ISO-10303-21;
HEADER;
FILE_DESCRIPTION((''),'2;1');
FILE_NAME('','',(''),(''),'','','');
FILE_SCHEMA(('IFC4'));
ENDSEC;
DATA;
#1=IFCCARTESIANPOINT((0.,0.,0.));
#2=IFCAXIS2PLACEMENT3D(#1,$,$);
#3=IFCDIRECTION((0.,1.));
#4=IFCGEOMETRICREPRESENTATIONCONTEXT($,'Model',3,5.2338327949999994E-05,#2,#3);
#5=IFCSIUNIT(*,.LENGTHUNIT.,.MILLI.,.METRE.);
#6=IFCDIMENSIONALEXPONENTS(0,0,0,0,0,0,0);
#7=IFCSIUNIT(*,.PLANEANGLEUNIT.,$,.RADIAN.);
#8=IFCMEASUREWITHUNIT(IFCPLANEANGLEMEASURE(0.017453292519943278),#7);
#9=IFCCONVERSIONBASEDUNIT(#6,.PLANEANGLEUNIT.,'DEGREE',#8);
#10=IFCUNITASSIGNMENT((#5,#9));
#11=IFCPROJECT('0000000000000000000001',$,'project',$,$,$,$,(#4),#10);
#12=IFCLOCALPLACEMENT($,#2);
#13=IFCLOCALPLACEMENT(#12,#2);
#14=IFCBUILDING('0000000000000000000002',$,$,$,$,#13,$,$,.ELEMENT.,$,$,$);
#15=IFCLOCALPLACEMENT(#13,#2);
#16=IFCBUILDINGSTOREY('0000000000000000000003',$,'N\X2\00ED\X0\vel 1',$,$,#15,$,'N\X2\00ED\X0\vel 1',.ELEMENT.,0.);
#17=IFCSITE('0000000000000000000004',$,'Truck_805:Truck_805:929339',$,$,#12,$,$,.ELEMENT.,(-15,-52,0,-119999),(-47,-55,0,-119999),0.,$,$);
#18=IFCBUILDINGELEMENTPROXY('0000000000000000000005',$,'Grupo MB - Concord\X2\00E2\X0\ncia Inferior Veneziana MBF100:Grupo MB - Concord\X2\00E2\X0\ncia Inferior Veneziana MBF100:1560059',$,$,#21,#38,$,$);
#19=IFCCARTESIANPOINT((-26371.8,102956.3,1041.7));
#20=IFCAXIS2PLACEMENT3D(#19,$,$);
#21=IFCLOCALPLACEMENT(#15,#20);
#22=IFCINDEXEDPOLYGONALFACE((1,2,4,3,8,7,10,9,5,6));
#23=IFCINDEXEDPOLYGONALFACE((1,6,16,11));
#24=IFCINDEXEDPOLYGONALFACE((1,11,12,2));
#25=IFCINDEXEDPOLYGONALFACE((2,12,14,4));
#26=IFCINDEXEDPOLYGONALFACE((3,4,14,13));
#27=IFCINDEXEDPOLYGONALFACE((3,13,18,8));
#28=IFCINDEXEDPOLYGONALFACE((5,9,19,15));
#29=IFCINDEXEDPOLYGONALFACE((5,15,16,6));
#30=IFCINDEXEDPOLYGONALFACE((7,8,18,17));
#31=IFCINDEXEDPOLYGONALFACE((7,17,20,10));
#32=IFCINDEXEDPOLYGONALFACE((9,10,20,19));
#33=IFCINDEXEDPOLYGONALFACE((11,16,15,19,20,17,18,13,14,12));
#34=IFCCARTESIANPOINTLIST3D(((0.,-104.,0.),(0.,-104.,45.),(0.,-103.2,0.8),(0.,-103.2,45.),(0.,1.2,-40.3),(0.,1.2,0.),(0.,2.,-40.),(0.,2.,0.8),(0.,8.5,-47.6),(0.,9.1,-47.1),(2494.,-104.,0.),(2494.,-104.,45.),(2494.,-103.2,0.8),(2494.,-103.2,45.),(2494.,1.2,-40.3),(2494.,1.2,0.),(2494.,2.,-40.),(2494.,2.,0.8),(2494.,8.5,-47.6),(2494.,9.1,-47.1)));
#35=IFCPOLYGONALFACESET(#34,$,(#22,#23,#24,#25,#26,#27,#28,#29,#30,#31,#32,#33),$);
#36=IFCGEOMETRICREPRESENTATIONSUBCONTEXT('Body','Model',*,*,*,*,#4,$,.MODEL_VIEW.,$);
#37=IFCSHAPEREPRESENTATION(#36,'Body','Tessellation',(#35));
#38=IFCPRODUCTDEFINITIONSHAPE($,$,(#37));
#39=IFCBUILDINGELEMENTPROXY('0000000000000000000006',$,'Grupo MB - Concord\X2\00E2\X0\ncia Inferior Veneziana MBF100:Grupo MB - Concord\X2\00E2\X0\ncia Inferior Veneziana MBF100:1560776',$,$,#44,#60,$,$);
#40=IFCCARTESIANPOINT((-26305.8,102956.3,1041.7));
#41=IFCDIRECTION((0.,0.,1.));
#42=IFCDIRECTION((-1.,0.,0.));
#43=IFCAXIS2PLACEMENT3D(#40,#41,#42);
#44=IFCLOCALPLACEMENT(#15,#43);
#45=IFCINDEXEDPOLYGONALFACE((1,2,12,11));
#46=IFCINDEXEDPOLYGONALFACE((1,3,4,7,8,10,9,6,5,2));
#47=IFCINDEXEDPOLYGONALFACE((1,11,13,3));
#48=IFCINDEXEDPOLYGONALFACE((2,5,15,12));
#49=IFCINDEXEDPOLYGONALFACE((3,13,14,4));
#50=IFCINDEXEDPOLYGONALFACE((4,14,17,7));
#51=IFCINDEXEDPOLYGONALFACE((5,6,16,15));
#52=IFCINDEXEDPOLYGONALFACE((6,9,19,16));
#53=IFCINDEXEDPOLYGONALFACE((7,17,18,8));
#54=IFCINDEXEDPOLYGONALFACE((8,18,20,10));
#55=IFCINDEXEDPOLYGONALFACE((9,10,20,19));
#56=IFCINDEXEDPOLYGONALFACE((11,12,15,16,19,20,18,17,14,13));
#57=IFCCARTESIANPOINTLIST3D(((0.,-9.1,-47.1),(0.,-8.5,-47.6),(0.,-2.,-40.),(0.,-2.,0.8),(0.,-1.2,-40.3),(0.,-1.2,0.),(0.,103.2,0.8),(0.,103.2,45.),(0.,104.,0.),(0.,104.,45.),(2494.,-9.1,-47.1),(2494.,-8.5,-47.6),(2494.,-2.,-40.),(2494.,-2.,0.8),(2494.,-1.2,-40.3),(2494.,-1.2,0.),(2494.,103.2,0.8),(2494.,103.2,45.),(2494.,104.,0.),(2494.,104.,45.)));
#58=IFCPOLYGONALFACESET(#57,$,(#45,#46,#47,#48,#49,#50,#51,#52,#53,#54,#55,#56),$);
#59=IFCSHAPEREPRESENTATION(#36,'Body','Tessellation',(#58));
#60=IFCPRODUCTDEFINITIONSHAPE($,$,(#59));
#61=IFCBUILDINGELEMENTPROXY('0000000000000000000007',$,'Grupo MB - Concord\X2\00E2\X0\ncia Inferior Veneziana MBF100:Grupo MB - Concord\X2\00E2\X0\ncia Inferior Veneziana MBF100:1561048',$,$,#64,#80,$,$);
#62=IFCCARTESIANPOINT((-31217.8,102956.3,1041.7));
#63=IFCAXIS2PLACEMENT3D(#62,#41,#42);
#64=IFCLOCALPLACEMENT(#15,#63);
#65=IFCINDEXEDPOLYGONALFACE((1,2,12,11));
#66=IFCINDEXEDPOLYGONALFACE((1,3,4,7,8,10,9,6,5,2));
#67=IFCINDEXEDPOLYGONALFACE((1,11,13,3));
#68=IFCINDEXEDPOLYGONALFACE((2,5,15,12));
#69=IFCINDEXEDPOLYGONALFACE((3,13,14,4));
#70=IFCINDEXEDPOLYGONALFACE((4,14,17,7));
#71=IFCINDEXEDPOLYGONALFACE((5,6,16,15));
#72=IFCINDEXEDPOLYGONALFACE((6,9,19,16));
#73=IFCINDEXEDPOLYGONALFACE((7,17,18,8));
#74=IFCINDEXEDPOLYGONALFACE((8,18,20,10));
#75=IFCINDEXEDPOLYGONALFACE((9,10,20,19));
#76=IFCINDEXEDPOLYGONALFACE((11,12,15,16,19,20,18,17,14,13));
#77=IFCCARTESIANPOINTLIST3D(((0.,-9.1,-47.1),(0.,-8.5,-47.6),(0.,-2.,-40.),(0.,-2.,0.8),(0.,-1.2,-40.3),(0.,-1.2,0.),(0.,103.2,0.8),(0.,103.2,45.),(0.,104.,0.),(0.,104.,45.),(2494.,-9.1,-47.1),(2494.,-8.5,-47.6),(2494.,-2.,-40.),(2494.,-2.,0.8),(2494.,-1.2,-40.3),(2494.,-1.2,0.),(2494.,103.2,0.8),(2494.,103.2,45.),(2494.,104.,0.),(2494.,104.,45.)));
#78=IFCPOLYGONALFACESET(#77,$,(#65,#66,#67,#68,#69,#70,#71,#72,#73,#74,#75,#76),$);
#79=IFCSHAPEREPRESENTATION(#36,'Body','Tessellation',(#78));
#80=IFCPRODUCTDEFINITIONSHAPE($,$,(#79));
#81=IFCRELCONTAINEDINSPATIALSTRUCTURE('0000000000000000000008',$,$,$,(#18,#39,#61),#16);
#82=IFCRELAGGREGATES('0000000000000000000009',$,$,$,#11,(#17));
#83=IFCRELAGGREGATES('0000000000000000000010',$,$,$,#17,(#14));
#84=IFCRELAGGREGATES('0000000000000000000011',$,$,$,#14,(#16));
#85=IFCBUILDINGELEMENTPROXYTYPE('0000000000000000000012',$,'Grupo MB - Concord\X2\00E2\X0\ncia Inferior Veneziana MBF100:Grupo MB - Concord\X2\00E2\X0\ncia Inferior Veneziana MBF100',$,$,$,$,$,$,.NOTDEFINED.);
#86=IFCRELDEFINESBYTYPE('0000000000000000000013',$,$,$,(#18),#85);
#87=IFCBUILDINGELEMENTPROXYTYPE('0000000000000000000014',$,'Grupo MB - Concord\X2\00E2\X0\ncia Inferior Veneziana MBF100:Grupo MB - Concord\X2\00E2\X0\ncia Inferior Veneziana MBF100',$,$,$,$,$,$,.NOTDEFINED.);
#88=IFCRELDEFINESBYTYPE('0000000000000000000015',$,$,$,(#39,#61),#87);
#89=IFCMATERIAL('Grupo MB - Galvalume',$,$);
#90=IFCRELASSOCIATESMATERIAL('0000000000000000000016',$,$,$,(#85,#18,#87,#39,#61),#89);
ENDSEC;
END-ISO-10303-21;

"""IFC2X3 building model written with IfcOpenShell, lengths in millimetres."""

from ifc_helpers import new_model, entity, si_unit, converted_unit, direction, frame, origin, place, context, subcontext, project, spatial, polyline, outline, extrude, source, transform, mapped, material, type_object, type_shapes, element, save


model = new_model("IFC2X3")

# Units and contexts
model_context = context("Model", 3, precision=5.2338327949999994e-05, world=origin(), true_north=direction((0.0, 1.0)))
body_context = subcontext(model_context, "Body", "Model", "MODEL_VIEW")
ifc_project = project(units=[si_unit("LENGTHUNIT", "METRE", prefix="MILLI"), converted_unit("PLANEANGLEUNIT", "DEGREE", entity("IfcPlaneAngleMeasure", 0.017453292519943278), si_unit("PLANEANGLEUNIT", "RADIAN"), dimensions=[0, 0, 0, 0, 0, 0, 0])], contexts=[model_context])

# Site, building, storey
site_placement = place(None, origin())
site = spatial("IfcSite", under=ifc_project, at=site_placement, Name="Truck_805:Truck_805:929339", CompositionType="ELEMENT", RefLatitude=(-15, -52, 0, -119999), RefLongitude=(-47, -55, 0, -119999), RefElevation=0.0)
building_placement = place(site_placement, origin())
building = spatial("IfcBuilding", under=site, at=building_placement, CompositionType="ELEMENT")
storey_placement = place(building_placement, origin())
storey = spatial("IfcBuildingStorey", under=building, at=storey_placement, Name="Nível 1", LongName="Nível 1", CompositionType="ELEMENT", Elevation=0.0)

# Building element proxies
ifc_material_1 = material(Name="Grupo MB - Galvalume")
building_element_proxy_type_1 = type_object("IfcBuildingElementProxyType", Name="Grupo MB - Concordância Inferior Veneziana MBF100:Grupo MB - Concordância Inferior Veneziana MBF100", PredefinedType="NOTDEFINED", material=ifc_material_1)
shared_shape_1 = source(origin(), body_context, "Body", "SweptSolid", [
    extrude(outline(polyline([(-8.3, 40.2), (32.0, 40.2), (39.3, 47.5), (38.7, 48.1), (31.7, 41.0), (-9.1, 41.0), (-9.1, -64.2), (-53.3, -64.2), (-53.3, -65.0), (-8.3, -65.0), (-8.3, 40.2)])), frame((0.0, -39.0, -8.3), z_axis=(1.0, 0.0, 0.0), x_axis=(0.0, 0.0, -1.0)), (0.0, 0.0, 1.0), 2494.0),
])
type_shapes(building_element_proxy_type_1, [shared_shape_1])
proxy_placement = place(storey_placement, frame((-26371.8, 102956.3, 1041.7)))
element("IfcBuildingElementProxy", 1, at=proxy_placement, inside=storey, type_object=building_element_proxy_type_1, material=ifc_material_1, Name="Grupo MB - Concordância Inferior Veneziana MBF100:Grupo MB - Concordância Inferior Veneziana MBF100:1560059", context=body_context, shape_type="MappedRepresentation", body=[
    mapped(shared_shape_1, transform((0.0, 0.0, 0.0), scale=1.0)),
])
building_element_proxy_type_2 = type_object("IfcBuildingElementProxyType", Name="Grupo MB - Concordância Inferior Veneziana MBF100:Grupo MB - Concordância Inferior Veneziana MBF100", PredefinedType="NOTDEFINED", material=ifc_material_1)
shared_shape_2 = source(origin(), body_context, "Body", "SweptSolid", [
    extrude(outline(polyline([(-40.2, 8.3), (65.0, 8.3), (65.0, 53.3), (64.2, 53.3), (64.2, 9.1), (-41.0, 9.1), (-41.0, -31.7), (-48.1, -38.7), (-47.5, -39.3), (-40.2, -32.0), (-40.2, 8.3)])), frame((0.0, 39.0, -8.3), z_axis=(1.0, 0.0, 0.0), x_axis=(0.0, 1.0, 0.0)), (0.0, 0.0, 1.0), 2494.0),
])
type_shapes(building_element_proxy_type_2, [shared_shape_2])
for number, where, z_axis, x_axis, name in (
    (2, (-26305.8, 102956.3, 1041.7), (0.0, 0.0, 1.0), (-1.0, 0.0, 0.0), "Grupo MB - Concordância Inferior Veneziana MBF100:Grupo MB - Concordância Inferior Veneziana MBF100:1560776"),
    (3, (-31217.8, 102956.3, 1041.7), (0.0, 0.0, 1.0), (-1.0, 0.0, 0.0), "Grupo MB - Concordância Inferior Veneziana MBF100:Grupo MB - Concordância Inferior Veneziana MBF100:1561048"),
):
    element("IfcBuildingElementProxy", number, at=place(storey_placement, frame(where, z_axis=z_axis, x_axis=x_axis)), inside=storey, type_object=building_element_proxy_type_2, material=ifc_material_1, Name=name, context=body_context, shape_type="MappedRepresentation", body=[
        mapped(shared_shape_2, transform((0.0, 0.0, 0.0), scale=1.0)),
    ])

save(model, "model.ifc")
